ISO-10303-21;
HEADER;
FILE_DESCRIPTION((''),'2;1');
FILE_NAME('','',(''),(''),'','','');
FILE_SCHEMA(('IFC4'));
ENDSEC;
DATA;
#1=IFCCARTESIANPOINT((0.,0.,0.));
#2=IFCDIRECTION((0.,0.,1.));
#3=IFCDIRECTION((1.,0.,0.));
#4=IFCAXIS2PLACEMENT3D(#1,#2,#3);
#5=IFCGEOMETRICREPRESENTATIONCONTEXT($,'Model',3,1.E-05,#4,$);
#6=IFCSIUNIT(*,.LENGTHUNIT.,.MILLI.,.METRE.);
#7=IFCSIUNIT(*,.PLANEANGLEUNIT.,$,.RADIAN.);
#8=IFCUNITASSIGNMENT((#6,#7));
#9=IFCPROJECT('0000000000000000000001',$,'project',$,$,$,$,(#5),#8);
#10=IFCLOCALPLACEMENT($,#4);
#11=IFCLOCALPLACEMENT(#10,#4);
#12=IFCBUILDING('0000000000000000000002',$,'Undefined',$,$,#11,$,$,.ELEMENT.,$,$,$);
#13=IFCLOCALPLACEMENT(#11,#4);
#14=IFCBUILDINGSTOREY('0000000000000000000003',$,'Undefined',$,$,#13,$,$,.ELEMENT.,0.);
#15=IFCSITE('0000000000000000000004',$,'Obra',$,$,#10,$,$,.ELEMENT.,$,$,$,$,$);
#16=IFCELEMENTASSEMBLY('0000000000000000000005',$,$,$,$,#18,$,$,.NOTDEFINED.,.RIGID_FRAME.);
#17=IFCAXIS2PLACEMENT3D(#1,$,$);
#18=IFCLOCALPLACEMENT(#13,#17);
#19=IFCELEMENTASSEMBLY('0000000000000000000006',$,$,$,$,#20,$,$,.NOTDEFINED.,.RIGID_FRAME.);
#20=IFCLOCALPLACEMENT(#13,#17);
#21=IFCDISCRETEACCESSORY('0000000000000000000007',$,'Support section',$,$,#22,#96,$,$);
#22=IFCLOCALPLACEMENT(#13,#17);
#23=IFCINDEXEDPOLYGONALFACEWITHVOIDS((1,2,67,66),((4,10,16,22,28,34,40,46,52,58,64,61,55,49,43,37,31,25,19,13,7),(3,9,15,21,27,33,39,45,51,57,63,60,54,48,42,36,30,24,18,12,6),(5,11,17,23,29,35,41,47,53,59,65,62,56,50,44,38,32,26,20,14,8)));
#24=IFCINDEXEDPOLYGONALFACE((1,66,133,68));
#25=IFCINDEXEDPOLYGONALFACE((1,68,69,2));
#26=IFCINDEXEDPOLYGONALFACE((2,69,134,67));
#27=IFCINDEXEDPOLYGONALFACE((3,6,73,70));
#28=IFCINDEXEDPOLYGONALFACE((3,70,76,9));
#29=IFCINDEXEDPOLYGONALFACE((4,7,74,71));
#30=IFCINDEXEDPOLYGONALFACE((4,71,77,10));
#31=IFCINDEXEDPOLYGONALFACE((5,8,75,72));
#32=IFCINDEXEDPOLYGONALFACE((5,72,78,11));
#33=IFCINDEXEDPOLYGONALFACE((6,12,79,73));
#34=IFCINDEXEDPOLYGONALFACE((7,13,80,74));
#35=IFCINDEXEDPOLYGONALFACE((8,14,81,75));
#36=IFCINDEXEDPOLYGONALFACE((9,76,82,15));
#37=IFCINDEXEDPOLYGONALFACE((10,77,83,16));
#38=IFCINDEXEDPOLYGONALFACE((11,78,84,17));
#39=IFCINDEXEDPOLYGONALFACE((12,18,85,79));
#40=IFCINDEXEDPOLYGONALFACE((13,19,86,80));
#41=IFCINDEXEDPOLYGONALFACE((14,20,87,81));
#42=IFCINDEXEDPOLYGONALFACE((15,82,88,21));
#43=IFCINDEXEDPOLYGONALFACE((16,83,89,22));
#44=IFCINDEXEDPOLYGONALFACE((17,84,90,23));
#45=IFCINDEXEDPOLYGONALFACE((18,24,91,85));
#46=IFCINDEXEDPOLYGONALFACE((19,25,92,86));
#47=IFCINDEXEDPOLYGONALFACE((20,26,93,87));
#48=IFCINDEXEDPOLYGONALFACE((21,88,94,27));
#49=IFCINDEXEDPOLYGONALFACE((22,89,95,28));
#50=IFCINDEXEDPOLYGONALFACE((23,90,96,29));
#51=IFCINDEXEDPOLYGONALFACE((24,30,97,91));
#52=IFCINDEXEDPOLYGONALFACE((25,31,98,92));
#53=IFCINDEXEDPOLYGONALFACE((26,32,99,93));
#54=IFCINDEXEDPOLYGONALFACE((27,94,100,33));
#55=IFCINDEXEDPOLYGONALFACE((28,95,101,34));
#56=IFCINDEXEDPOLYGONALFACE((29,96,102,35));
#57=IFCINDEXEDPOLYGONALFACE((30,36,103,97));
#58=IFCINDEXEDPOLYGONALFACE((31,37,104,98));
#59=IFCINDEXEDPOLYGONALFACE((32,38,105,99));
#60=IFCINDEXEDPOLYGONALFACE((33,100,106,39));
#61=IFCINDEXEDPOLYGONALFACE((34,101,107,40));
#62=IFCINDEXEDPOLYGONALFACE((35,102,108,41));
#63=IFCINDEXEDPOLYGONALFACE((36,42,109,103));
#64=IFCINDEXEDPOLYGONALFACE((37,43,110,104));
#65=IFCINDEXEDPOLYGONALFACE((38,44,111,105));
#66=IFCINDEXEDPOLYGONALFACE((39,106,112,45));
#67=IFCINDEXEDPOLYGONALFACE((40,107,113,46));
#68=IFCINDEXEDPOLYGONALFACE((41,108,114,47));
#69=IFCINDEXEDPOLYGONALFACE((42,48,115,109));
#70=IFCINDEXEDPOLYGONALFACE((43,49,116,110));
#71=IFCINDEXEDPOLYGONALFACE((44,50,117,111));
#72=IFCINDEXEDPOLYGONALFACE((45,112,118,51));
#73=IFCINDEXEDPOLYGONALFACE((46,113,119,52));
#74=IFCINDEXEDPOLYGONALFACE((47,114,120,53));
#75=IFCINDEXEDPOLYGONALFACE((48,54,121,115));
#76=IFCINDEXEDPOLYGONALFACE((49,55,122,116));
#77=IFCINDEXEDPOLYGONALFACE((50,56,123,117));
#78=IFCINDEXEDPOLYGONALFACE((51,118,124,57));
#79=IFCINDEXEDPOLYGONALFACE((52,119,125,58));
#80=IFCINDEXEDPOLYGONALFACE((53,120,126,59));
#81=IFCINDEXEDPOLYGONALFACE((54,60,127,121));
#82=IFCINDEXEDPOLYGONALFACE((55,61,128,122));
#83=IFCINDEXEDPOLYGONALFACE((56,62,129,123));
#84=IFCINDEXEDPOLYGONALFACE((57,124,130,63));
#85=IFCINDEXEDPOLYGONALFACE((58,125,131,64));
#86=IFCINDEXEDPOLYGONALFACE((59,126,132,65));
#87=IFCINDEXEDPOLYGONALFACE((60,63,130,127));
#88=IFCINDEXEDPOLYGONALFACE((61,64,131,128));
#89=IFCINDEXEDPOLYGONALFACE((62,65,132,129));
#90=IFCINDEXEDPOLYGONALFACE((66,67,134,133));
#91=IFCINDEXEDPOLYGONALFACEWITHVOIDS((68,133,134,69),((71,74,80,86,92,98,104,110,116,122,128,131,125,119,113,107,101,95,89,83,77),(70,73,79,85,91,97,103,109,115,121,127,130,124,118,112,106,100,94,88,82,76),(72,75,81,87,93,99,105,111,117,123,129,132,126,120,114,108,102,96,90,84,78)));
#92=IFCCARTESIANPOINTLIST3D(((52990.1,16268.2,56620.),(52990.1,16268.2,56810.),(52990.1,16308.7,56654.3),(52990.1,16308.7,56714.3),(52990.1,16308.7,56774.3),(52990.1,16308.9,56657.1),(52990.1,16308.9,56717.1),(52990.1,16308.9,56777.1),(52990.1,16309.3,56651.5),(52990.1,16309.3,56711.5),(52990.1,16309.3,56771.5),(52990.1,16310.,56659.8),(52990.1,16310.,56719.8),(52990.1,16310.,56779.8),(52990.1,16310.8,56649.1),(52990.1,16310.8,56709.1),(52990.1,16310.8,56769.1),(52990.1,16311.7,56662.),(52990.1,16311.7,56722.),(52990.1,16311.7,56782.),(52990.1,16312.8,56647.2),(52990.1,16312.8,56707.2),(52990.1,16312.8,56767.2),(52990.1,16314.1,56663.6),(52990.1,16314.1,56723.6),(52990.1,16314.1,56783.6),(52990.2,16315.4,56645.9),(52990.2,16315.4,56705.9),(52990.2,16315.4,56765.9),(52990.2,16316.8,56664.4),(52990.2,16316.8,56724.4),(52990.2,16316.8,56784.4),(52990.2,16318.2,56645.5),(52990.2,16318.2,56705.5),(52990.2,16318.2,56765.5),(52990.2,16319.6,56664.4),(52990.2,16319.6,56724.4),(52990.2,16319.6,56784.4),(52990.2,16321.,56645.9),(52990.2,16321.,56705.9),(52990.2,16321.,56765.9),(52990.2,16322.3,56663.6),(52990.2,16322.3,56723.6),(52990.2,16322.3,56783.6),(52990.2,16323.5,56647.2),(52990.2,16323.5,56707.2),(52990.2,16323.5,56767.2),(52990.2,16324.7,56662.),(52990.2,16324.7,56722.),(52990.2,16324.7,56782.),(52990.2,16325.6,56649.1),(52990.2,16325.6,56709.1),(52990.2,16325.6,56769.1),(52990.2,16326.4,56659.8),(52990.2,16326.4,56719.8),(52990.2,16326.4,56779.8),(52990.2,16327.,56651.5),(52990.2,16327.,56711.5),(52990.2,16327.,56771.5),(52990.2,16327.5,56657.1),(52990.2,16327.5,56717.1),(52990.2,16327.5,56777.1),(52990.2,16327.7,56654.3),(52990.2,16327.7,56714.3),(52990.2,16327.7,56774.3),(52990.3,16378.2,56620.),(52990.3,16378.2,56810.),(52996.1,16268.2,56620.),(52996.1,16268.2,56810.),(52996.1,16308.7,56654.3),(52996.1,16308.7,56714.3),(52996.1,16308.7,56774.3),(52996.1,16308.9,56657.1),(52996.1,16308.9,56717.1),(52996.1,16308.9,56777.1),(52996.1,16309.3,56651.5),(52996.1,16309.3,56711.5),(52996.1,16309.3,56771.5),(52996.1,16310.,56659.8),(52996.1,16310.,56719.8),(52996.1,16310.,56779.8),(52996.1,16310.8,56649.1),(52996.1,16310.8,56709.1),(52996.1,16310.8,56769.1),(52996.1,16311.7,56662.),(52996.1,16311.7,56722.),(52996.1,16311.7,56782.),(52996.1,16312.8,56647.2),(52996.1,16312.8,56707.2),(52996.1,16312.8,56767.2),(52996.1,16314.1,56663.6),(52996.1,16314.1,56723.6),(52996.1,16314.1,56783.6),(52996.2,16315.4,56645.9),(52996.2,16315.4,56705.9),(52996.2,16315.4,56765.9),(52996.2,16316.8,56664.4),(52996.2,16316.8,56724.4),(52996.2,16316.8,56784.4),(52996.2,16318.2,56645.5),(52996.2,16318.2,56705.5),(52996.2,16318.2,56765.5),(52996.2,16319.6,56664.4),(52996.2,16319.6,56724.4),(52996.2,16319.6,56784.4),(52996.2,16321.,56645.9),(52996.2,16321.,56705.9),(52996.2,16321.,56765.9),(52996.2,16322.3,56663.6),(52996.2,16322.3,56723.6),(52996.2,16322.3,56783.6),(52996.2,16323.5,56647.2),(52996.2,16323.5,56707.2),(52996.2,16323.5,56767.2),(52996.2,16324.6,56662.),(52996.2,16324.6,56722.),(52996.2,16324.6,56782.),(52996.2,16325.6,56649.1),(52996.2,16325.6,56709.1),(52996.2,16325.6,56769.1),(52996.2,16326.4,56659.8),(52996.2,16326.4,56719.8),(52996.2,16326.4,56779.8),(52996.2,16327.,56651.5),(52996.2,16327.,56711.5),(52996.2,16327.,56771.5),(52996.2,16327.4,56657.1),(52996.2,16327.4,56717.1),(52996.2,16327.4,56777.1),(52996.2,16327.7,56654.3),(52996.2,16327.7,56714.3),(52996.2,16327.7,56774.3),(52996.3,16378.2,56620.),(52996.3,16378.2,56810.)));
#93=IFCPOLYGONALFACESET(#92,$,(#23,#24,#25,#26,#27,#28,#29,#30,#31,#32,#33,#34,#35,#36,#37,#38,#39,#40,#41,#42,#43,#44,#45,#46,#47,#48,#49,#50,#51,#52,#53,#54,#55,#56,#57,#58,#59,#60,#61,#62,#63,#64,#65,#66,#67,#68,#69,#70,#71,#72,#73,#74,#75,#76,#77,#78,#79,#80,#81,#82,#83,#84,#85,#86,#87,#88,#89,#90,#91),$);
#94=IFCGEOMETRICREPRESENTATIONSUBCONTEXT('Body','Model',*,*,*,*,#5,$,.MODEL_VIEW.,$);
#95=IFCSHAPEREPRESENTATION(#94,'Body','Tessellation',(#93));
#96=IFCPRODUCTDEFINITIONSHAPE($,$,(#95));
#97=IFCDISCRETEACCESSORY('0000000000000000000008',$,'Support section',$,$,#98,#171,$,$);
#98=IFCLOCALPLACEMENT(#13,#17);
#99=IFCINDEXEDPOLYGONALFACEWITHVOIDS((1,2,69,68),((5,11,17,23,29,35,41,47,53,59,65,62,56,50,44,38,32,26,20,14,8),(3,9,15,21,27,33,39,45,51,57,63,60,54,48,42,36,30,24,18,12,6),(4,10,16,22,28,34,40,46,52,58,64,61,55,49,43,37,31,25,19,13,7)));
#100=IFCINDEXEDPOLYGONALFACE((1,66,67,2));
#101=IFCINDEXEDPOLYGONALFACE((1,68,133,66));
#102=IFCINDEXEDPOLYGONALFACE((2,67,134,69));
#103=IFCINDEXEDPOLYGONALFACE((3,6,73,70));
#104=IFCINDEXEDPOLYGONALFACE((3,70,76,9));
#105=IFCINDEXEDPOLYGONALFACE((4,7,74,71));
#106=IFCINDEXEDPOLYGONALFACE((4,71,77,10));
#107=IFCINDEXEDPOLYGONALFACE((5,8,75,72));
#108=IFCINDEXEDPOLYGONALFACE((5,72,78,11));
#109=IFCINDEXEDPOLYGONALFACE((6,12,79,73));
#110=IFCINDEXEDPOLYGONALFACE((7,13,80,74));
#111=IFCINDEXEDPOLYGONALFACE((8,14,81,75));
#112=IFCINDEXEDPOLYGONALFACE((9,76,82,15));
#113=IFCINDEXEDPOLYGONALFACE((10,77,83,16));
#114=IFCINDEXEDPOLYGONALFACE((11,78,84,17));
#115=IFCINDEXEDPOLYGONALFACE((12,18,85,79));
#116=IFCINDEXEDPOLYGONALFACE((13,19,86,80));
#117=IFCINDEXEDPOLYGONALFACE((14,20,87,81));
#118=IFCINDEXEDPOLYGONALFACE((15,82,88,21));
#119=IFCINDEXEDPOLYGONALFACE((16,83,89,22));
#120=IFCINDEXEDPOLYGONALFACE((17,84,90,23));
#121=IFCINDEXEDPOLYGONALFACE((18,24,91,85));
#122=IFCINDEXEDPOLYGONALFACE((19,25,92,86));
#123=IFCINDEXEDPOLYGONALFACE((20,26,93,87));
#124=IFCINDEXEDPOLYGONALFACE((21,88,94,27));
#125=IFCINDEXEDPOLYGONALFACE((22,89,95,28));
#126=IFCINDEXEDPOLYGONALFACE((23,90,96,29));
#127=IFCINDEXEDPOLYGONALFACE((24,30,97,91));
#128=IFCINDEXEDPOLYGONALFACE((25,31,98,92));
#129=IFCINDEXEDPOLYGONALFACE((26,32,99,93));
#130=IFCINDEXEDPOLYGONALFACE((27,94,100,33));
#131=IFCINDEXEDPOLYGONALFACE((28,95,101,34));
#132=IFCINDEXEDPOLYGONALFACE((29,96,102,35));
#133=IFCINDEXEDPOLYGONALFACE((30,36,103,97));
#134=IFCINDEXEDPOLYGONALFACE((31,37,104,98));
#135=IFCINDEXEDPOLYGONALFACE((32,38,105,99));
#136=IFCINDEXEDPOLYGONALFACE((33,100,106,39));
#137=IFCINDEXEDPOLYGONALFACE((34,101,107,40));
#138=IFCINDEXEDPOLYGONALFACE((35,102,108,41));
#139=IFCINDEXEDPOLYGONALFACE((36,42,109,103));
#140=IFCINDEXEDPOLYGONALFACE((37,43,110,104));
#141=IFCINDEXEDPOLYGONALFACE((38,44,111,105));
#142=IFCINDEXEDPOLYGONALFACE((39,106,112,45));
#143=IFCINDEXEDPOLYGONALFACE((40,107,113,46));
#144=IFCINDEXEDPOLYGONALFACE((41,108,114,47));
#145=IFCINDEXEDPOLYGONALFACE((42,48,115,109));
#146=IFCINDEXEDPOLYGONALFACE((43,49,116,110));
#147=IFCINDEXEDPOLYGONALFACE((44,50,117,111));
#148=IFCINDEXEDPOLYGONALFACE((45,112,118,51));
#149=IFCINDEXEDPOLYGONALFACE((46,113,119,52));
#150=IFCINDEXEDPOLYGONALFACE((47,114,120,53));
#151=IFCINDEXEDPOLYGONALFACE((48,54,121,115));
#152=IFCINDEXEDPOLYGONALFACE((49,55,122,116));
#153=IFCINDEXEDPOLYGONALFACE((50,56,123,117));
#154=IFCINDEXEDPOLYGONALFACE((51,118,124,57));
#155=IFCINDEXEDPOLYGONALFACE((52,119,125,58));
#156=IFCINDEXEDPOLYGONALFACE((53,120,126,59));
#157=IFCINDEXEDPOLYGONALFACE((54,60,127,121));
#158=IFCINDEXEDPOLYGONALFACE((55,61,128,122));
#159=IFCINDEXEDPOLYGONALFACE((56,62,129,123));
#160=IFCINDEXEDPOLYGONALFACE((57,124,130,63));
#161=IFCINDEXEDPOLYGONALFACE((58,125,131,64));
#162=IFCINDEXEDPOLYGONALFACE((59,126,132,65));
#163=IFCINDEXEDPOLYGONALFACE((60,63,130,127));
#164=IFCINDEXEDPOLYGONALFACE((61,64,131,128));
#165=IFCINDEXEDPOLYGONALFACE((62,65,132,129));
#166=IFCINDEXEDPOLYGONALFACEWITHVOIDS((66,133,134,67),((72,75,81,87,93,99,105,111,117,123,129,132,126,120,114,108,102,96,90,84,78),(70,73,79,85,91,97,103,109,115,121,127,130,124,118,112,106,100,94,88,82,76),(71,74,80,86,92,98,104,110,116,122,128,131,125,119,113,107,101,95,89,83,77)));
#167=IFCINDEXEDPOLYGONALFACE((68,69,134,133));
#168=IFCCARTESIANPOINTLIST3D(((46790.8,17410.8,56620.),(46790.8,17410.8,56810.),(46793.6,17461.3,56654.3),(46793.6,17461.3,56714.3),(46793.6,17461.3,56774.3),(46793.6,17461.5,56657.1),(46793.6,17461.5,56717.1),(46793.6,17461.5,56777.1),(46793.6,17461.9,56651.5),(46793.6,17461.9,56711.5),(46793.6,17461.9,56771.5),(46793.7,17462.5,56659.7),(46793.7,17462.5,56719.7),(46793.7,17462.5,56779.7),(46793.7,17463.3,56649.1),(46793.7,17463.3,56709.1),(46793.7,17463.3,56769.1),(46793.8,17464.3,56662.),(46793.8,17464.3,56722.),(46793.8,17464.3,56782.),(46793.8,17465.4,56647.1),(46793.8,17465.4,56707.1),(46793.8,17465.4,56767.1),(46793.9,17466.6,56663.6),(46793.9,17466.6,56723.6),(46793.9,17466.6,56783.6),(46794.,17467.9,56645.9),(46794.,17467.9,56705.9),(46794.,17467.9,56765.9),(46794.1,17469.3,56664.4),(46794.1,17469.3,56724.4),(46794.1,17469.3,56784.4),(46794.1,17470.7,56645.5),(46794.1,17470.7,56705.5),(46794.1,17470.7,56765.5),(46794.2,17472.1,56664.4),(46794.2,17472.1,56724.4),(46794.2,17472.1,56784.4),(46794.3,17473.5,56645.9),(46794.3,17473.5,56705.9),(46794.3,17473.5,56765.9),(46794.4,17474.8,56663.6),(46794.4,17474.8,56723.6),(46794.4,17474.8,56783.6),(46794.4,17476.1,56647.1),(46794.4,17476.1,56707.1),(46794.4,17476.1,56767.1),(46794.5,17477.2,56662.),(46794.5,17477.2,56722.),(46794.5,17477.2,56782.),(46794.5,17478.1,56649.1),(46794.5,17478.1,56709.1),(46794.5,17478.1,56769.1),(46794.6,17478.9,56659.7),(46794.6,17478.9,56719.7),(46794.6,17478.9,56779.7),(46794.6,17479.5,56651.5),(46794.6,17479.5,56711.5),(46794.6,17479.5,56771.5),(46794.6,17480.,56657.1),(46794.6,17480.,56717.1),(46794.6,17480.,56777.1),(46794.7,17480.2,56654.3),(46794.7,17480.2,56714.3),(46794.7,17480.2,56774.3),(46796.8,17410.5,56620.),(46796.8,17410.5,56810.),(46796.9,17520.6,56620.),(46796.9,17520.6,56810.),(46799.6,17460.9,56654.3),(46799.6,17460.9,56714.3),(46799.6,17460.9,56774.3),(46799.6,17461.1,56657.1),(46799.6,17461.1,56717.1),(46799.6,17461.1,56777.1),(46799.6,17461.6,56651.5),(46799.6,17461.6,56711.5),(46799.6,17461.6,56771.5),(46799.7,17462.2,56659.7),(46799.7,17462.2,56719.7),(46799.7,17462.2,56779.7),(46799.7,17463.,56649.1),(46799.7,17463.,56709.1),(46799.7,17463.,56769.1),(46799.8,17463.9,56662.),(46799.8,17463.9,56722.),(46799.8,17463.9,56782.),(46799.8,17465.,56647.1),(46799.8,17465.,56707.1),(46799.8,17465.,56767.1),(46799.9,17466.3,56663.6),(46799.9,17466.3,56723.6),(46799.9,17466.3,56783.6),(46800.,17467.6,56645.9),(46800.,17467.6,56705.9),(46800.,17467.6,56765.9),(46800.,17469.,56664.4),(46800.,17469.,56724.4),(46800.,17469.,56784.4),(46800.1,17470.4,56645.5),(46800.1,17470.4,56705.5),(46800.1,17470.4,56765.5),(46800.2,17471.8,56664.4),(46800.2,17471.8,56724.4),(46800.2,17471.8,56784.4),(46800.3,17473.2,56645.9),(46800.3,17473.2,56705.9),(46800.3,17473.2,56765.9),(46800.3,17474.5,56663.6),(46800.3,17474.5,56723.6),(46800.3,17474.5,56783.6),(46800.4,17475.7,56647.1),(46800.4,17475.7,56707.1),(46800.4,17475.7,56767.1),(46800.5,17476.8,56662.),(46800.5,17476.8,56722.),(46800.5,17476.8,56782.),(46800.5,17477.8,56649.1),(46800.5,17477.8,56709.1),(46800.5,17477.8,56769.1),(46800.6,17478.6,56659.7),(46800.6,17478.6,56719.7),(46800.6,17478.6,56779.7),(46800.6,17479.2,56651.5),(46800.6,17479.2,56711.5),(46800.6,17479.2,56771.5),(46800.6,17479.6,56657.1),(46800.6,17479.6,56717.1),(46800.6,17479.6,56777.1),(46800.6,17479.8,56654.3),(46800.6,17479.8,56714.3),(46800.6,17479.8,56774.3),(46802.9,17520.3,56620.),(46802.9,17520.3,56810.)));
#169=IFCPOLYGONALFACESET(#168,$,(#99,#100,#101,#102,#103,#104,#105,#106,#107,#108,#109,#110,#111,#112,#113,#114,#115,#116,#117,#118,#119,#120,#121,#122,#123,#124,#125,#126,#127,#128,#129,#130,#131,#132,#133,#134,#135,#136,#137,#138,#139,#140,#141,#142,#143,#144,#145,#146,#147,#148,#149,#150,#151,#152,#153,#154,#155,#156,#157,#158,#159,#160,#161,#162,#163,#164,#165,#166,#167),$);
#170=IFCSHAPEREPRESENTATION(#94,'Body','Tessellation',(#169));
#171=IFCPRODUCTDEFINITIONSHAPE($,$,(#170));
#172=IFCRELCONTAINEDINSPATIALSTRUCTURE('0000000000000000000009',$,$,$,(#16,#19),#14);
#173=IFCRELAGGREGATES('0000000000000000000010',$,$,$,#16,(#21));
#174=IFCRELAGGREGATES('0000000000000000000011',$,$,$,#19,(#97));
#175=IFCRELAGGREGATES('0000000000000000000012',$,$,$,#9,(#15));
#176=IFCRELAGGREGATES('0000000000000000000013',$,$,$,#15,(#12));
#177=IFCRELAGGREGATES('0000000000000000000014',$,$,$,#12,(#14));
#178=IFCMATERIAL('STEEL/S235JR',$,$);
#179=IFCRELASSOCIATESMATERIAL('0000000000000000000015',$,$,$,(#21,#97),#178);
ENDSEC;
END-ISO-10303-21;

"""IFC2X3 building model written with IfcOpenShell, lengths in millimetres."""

from ifc_helpers import new_model, si_unit, frame, origin_with_axes, origin_2d_with_axis, place, context, subcontext, project, spatial, rectangle, circle, extrude, source, transform, mapped, material, element, aggregate, save


model = new_model("IFC2X3")

# Units and contexts
model_context = context("Model", 3, precision=1e-05, world=origin_with_axes())
body_context = subcontext(model_context, "Body", "Model", "MODEL_VIEW")
ifc_project = project(units=[si_unit("LENGTHUNIT", "METRE", prefix="MILLI"), si_unit("PLANEANGLEUNIT", "RADIAN")], contexts=[model_context])

# Site, building, storey
site_placement = place(None, origin_with_axes())
site = spatial("IfcSite", under=ifc_project, at=site_placement, Name="Obra", CompositionType="ELEMENT")
building_placement = place(site_placement, origin_with_axes())
building = spatial("IfcBuilding", under=site, at=building_placement, Name="Undefined", CompositionType="ELEMENT")
storey_placement = place(building_placement, origin_with_axes())
storey = spatial("IfcBuildingStorey", under=building, at=storey_placement, Name="Undefined", CompositionType="ELEMENT", Elevation=0.0)

# Element assemblies
ifc_material_1 = material(Name="STEEL/S235JR")
assembly_1_placement = place(storey_placement, origin_with_axes())
assembly_1 = element("IfcElementAssembly", 1, at=assembly_1_placement, inside=storey, AssemblyPlace="NOTDEFINED", PredefinedType="RIGID_FRAME")
assembly_2_placement = place(storey_placement, origin_with_axes())
assembly_2 = element("IfcElementAssembly", 2, at=assembly_2_placement, inside=storey, AssemblyPlace="NOTDEFINED", PredefinedType="RIGID_FRAME")

# Discrete accessories, openings
shared_shape_1 = source(origin_with_axes(), body_context, "Body", "SweptSolid", [
    extrude(circle(Radius=9.5, at=origin_2d_with_axis()), frame((0.0, -9.2, 0.0), z_axis=(0.0, 1.0, 0.0), x_axis=(1.0, 0.0, 0.0)), (0.0, 0.0, 1.0), 6.2),
])
discrete_accessory_1_placement = place(assembly_1_placement, frame((52993.2, 16323.2, 56620.0), z_axis=(0.0, 0.0, 1.0), x_axis=(0.001649, 0.999999, 0.0)))
discrete_accessory_1 = element("IfcDiscreteAccessory", 3, at=discrete_accessory_1_placement, material=ifc_material_1, Name="Support section", context=body_context, shape_type="SweptSolid", body=[
    extrude(rectangle(XDim=6.0, YDim=110.0, at=origin_2d_with_axis()), frame((0.0, 0.0, 190.0), z_axis=(0.0, 0.0, -1.0), x_axis=(0.0, 1.0, 0.0)), (0.0, 0.0, 1.0), 190.0),
])
opening_1_placement = place(assembly_1_placement, frame((52999.3, 16368.2, 56835.0), z_axis=(-0.001649, -0.999999, 0.0), x_axis=(0.0, 0.0, -1.0)))
element("IfcOpeningElement", 4, at=opening_1_placement, cuts=discrete_accessory_1, ObjectType="Opening", context=body_context, shape_type="MappedRepresentation", body=[
    mapped(shared_shape_1, transform((60.0, 0.0, 50.0))),
    mapped(shared_shape_1, transform((120.0, 0.0, 50.0))),
    mapped(shared_shape_1, transform((180.0, 0.0, 50.0))),
])
aggregate(assembly_1, [discrete_accessory_1])
discrete_accessory_2_placement = place(assembly_2_placement, frame((46796.9, 17465.6, 56620.0), z_axis=(0.0, 0.0, 1.0), x_axis=(-0.055268, -0.998472, 0.0)))
discrete_accessory_2 = element("IfcDiscreteAccessory", 5, at=discrete_accessory_2_placement, material=ifc_material_1, Name="Support section", context=body_context, shape_type="SweptSolid", body=[
    extrude(rectangle(XDim=6.0, YDim=110.0, at=origin_2d_with_axis()), frame((0.0, 0.0, 190.0), z_axis=(0.0, 0.0, -1.0), x_axis=(0.0, 1.0, 0.0)), (0.0, 0.0, 1.0), 190.0),
])
opening_2_placement = place(assembly_2_placement, frame((46788.3, 17421.0, 56835.0), z_axis=(0.055268, 0.998472, 0.0), x_axis=(0.0, 0.0, -1.0)))
element("IfcOpeningElement", 6, at=opening_2_placement, cuts=discrete_accessory_2, ObjectType="Opening", context=body_context, shape_type="MappedRepresentation", body=[
    mapped(shared_shape_1, transform((60.0, 0.0, 50.0))),
    mapped(shared_shape_1, transform((120.0, 0.0, 50.0))),
    mapped(shared_shape_1, transform((180.0, 0.0, 50.0))),
])
aggregate(assembly_2, [discrete_accessory_2])

save(model, "model.ifc")
